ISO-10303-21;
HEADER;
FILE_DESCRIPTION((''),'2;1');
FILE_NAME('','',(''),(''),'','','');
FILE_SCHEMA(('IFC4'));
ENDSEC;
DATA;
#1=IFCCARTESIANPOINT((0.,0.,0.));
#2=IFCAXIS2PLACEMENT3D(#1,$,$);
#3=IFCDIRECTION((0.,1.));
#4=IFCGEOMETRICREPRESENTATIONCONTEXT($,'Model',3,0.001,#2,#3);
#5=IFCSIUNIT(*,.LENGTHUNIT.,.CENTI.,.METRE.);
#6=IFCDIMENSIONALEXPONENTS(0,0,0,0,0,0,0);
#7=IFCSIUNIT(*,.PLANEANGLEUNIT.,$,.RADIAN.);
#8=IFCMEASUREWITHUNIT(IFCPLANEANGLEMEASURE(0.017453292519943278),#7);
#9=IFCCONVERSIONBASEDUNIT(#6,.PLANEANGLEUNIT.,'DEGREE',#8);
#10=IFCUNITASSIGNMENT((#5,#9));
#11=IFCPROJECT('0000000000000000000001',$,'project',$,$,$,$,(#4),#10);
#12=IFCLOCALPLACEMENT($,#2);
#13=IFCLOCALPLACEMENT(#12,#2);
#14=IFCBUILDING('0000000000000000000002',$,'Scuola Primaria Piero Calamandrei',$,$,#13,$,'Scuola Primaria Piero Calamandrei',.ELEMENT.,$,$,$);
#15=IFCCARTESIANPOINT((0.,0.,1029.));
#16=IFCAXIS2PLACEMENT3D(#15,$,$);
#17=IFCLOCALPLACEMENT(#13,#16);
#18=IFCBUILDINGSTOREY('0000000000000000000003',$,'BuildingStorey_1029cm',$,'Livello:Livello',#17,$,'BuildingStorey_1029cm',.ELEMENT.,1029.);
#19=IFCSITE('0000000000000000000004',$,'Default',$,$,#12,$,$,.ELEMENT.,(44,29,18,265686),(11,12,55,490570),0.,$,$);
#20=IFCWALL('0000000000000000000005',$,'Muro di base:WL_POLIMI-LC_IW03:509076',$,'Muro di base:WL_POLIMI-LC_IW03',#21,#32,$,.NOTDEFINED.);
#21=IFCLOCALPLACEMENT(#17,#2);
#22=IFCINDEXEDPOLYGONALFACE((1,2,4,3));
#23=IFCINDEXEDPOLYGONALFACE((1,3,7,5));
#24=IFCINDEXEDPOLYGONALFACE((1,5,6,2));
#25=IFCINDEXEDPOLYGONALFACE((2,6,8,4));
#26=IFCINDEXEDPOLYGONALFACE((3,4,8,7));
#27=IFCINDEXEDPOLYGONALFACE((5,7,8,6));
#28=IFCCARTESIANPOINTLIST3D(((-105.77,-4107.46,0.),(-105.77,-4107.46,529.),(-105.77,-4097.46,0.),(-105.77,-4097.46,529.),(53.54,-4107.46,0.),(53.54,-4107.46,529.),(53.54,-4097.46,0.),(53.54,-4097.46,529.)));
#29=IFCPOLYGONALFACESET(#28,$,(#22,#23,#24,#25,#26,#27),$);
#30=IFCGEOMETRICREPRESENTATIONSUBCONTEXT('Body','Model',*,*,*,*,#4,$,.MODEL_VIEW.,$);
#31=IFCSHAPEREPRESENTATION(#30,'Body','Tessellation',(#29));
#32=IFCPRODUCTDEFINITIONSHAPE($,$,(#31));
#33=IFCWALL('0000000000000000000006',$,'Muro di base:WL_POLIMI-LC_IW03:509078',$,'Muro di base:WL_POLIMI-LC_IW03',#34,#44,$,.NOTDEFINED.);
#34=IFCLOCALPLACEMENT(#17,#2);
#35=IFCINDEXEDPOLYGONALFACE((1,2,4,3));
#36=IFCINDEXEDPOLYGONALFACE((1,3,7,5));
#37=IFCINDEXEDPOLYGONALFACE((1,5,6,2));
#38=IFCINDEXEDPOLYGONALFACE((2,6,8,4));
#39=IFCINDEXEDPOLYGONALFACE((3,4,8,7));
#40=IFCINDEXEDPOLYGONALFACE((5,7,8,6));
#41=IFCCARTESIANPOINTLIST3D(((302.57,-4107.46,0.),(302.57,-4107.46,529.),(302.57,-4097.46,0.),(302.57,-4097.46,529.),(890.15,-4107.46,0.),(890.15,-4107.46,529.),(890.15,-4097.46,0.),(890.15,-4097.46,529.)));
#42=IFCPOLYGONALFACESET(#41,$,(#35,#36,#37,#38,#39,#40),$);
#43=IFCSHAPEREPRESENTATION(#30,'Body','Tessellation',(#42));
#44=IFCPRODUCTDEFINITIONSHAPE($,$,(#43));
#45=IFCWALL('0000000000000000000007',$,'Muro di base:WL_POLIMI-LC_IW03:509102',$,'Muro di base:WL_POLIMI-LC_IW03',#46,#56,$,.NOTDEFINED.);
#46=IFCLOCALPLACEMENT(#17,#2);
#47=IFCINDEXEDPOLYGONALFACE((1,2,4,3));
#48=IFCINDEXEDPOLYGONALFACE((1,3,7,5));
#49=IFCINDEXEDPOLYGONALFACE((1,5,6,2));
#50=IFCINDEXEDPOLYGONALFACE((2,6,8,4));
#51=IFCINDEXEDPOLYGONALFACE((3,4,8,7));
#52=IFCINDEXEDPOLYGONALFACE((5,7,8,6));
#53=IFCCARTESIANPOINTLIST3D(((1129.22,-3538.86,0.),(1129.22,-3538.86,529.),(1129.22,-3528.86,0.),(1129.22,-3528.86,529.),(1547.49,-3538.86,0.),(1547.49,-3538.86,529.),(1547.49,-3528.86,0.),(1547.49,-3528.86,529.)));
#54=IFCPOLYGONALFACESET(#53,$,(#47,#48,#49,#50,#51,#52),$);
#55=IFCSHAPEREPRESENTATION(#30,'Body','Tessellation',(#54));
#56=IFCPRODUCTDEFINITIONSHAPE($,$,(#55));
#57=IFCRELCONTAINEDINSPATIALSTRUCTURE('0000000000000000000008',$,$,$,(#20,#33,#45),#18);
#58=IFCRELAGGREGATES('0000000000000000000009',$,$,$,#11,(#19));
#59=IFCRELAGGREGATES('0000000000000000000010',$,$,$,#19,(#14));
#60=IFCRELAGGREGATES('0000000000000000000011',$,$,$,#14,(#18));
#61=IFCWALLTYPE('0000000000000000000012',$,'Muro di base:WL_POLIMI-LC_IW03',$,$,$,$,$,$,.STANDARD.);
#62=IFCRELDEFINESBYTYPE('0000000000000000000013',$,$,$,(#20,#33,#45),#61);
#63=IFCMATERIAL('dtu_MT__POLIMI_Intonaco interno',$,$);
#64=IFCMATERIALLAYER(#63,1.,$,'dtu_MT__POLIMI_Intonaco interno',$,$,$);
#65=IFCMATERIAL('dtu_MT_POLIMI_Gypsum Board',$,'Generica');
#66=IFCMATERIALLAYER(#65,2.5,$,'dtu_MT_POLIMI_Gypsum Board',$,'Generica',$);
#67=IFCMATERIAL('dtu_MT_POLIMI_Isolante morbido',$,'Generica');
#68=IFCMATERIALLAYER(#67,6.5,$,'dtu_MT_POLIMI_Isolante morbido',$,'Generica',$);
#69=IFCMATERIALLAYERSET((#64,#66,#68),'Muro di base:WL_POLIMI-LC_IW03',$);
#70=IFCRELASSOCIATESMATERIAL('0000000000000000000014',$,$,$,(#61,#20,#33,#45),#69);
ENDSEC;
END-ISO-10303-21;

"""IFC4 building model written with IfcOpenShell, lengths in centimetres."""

from ifc_helpers import new_model, entity, si_unit, converted_unit, direction, frame, frame_2d, origin, place, context, subcontext, project, spatial, rectangle, extrude, material, layer, layer_set, layer_usage, type_object, element, save


model = new_model("IFC4")

# Units and contexts
model_context = context("Model", 3, precision=0.001, world=origin(), true_north=direction((0.0, 1.0)))
body_context = subcontext(model_context, "Body", "Model", "MODEL_VIEW")
ifc_project = project(units=[si_unit("LENGTHUNIT", "METRE", prefix="CENTI"), converted_unit("PLANEANGLEUNIT", "DEGREE", entity("IfcPlaneAngleMeasure", 0.017453292519943278), si_unit("PLANEANGLEUNIT", "RADIAN"), dimensions=[0, 0, 0, 0, 0, 0, 0])], contexts=[model_context])

# Site, building, storey
site_placement = place(None, origin())
site = spatial("IfcSite", under=ifc_project, at=site_placement, Name="Default", CompositionType="ELEMENT", RefLatitude=(44, 29, 18, 265686), RefLongitude=(11, 12, 55, 490570), RefElevation=0.0)
building_placement = place(site_placement, origin())
building = spatial("IfcBuilding", under=site, at=building_placement, Name="Scuola Primaria Piero Calamandrei", LongName="Scuola Primaria Piero Calamandrei", CompositionType="ELEMENT")
storey_placement = place(building_placement, frame((0.0, 0.0, 1029.0)))
storey = spatial("IfcBuildingStorey", under=building, at=storey_placement, Name="BuildingStorey_1029cm", ObjectType="Livello:Livello", LongName="BuildingStorey_1029cm", CompositionType="ELEMENT", Elevation=1029.0)

# Shared definitions
ifc_material_1 = material(Name="dtu_MT__POLIMI_Intonaco interno")

# Shared definitions
ifc_material_2 = material(Name="dtu_MT_POLIMI_Gypsum Board", Category="Generica")
ifc_material_3 = material(Name="dtu_MT_POLIMI_Isolante morbido", Category="Generica")

# Walls
ifc_layer_1 = layer(ifc_material_1, 1.0, Name="dtu_MT__POLIMI_Intonaco interno")
ifc_layer_2 = layer(ifc_material_2, 2.5, Name="dtu_MT_POLIMI_Gypsum Board", Category="Generica")
ifc_layer_3 = layer(ifc_material_3, 6.5, Name="dtu_MT_POLIMI_Isolante morbido", Category="Generica")
ifc_layer_set_1 = layer_set([ifc_layer_1, ifc_layer_2, ifc_layer_3], Name="Muro di base:WL_POLIMI-LC_IW03")
wall_type_1 = type_object("IfcWallType", Name="Muro di base:WL_POLIMI-LC_IW03", PredefinedType="STANDARD", material=ifc_layer_set_1)
ifc_layer_usage_1 = layer_usage(ifc_layer_set_1, "AXIS2", "NEGATIVE", 5.0)
wall_1_placement = place(storey_placement, frame((53.54, -4102.46, 0.0), z_axis=(0.0, 0.0, 1.0), x_axis=(-1.0, 0.0, 0.0)))
element("IfcWall", 1, at=wall_1_placement, inside=storey, type_object=wall_type_1, material=ifc_layer_usage_1, Name="Muro di base:WL_POLIMI-LC_IW03:509076", ObjectType="Muro di base:WL_POLIMI-LC_IW03", PredefinedType="NOTDEFINED", context=body_context, shape_type="SweptSolid", body=[
    extrude(rectangle(XDim=159.31, YDim=10.0, at=frame_2d((79.66, 0.0), x_axis=(-1.0, 0.0))), origin(), (0.0, 0.0, 1.0), 529.0),
])
ifc_layer_usage_2 = layer_usage(ifc_layer_set_1, "AXIS2", "NEGATIVE", 5.0)
wall_2_placement = place(storey_placement, frame((302.57, -4102.46, 0.0)))
element("IfcWall", 2, at=wall_2_placement, inside=storey, type_object=wall_type_1, material=ifc_layer_usage_2, Name="Muro di base:WL_POLIMI-LC_IW03:509078", ObjectType="Muro di base:WL_POLIMI-LC_IW03", PredefinedType="NOTDEFINED", context=body_context, shape_type="SweptSolid", body=[
    extrude(rectangle(XDim=587.58, YDim=10.0, at=frame_2d((293.79, 0.0), x_axis=(-1.0, 0.0))), origin(), (0.0, 0.0, 1.0), 529.0),
])
ifc_layer_usage_3 = layer_usage(ifc_layer_set_1, "AXIS2", "NEGATIVE", 5.0)
wall_3_placement = place(storey_placement, frame((1547.49, -3533.86, 0.0), z_axis=(0.0, 0.0, 1.0), x_axis=(-1.0, 0.0, 0.0)))
element("IfcWall", 3, at=wall_3_placement, inside=storey, type_object=wall_type_1, material=ifc_layer_usage_3, Name="Muro di base:WL_POLIMI-LC_IW03:509102", ObjectType="Muro di base:WL_POLIMI-LC_IW03", PredefinedType="NOTDEFINED", context=body_context, shape_type="SweptSolid", body=[
    extrude(rectangle(XDim=418.26, YDim=10.0, at=frame_2d((209.13, 0.0), x_axis=(-1.0, 0.0))), origin(), (0.0, 0.0, 1.0), 529.0),
])

save(model, "model.ifc")
